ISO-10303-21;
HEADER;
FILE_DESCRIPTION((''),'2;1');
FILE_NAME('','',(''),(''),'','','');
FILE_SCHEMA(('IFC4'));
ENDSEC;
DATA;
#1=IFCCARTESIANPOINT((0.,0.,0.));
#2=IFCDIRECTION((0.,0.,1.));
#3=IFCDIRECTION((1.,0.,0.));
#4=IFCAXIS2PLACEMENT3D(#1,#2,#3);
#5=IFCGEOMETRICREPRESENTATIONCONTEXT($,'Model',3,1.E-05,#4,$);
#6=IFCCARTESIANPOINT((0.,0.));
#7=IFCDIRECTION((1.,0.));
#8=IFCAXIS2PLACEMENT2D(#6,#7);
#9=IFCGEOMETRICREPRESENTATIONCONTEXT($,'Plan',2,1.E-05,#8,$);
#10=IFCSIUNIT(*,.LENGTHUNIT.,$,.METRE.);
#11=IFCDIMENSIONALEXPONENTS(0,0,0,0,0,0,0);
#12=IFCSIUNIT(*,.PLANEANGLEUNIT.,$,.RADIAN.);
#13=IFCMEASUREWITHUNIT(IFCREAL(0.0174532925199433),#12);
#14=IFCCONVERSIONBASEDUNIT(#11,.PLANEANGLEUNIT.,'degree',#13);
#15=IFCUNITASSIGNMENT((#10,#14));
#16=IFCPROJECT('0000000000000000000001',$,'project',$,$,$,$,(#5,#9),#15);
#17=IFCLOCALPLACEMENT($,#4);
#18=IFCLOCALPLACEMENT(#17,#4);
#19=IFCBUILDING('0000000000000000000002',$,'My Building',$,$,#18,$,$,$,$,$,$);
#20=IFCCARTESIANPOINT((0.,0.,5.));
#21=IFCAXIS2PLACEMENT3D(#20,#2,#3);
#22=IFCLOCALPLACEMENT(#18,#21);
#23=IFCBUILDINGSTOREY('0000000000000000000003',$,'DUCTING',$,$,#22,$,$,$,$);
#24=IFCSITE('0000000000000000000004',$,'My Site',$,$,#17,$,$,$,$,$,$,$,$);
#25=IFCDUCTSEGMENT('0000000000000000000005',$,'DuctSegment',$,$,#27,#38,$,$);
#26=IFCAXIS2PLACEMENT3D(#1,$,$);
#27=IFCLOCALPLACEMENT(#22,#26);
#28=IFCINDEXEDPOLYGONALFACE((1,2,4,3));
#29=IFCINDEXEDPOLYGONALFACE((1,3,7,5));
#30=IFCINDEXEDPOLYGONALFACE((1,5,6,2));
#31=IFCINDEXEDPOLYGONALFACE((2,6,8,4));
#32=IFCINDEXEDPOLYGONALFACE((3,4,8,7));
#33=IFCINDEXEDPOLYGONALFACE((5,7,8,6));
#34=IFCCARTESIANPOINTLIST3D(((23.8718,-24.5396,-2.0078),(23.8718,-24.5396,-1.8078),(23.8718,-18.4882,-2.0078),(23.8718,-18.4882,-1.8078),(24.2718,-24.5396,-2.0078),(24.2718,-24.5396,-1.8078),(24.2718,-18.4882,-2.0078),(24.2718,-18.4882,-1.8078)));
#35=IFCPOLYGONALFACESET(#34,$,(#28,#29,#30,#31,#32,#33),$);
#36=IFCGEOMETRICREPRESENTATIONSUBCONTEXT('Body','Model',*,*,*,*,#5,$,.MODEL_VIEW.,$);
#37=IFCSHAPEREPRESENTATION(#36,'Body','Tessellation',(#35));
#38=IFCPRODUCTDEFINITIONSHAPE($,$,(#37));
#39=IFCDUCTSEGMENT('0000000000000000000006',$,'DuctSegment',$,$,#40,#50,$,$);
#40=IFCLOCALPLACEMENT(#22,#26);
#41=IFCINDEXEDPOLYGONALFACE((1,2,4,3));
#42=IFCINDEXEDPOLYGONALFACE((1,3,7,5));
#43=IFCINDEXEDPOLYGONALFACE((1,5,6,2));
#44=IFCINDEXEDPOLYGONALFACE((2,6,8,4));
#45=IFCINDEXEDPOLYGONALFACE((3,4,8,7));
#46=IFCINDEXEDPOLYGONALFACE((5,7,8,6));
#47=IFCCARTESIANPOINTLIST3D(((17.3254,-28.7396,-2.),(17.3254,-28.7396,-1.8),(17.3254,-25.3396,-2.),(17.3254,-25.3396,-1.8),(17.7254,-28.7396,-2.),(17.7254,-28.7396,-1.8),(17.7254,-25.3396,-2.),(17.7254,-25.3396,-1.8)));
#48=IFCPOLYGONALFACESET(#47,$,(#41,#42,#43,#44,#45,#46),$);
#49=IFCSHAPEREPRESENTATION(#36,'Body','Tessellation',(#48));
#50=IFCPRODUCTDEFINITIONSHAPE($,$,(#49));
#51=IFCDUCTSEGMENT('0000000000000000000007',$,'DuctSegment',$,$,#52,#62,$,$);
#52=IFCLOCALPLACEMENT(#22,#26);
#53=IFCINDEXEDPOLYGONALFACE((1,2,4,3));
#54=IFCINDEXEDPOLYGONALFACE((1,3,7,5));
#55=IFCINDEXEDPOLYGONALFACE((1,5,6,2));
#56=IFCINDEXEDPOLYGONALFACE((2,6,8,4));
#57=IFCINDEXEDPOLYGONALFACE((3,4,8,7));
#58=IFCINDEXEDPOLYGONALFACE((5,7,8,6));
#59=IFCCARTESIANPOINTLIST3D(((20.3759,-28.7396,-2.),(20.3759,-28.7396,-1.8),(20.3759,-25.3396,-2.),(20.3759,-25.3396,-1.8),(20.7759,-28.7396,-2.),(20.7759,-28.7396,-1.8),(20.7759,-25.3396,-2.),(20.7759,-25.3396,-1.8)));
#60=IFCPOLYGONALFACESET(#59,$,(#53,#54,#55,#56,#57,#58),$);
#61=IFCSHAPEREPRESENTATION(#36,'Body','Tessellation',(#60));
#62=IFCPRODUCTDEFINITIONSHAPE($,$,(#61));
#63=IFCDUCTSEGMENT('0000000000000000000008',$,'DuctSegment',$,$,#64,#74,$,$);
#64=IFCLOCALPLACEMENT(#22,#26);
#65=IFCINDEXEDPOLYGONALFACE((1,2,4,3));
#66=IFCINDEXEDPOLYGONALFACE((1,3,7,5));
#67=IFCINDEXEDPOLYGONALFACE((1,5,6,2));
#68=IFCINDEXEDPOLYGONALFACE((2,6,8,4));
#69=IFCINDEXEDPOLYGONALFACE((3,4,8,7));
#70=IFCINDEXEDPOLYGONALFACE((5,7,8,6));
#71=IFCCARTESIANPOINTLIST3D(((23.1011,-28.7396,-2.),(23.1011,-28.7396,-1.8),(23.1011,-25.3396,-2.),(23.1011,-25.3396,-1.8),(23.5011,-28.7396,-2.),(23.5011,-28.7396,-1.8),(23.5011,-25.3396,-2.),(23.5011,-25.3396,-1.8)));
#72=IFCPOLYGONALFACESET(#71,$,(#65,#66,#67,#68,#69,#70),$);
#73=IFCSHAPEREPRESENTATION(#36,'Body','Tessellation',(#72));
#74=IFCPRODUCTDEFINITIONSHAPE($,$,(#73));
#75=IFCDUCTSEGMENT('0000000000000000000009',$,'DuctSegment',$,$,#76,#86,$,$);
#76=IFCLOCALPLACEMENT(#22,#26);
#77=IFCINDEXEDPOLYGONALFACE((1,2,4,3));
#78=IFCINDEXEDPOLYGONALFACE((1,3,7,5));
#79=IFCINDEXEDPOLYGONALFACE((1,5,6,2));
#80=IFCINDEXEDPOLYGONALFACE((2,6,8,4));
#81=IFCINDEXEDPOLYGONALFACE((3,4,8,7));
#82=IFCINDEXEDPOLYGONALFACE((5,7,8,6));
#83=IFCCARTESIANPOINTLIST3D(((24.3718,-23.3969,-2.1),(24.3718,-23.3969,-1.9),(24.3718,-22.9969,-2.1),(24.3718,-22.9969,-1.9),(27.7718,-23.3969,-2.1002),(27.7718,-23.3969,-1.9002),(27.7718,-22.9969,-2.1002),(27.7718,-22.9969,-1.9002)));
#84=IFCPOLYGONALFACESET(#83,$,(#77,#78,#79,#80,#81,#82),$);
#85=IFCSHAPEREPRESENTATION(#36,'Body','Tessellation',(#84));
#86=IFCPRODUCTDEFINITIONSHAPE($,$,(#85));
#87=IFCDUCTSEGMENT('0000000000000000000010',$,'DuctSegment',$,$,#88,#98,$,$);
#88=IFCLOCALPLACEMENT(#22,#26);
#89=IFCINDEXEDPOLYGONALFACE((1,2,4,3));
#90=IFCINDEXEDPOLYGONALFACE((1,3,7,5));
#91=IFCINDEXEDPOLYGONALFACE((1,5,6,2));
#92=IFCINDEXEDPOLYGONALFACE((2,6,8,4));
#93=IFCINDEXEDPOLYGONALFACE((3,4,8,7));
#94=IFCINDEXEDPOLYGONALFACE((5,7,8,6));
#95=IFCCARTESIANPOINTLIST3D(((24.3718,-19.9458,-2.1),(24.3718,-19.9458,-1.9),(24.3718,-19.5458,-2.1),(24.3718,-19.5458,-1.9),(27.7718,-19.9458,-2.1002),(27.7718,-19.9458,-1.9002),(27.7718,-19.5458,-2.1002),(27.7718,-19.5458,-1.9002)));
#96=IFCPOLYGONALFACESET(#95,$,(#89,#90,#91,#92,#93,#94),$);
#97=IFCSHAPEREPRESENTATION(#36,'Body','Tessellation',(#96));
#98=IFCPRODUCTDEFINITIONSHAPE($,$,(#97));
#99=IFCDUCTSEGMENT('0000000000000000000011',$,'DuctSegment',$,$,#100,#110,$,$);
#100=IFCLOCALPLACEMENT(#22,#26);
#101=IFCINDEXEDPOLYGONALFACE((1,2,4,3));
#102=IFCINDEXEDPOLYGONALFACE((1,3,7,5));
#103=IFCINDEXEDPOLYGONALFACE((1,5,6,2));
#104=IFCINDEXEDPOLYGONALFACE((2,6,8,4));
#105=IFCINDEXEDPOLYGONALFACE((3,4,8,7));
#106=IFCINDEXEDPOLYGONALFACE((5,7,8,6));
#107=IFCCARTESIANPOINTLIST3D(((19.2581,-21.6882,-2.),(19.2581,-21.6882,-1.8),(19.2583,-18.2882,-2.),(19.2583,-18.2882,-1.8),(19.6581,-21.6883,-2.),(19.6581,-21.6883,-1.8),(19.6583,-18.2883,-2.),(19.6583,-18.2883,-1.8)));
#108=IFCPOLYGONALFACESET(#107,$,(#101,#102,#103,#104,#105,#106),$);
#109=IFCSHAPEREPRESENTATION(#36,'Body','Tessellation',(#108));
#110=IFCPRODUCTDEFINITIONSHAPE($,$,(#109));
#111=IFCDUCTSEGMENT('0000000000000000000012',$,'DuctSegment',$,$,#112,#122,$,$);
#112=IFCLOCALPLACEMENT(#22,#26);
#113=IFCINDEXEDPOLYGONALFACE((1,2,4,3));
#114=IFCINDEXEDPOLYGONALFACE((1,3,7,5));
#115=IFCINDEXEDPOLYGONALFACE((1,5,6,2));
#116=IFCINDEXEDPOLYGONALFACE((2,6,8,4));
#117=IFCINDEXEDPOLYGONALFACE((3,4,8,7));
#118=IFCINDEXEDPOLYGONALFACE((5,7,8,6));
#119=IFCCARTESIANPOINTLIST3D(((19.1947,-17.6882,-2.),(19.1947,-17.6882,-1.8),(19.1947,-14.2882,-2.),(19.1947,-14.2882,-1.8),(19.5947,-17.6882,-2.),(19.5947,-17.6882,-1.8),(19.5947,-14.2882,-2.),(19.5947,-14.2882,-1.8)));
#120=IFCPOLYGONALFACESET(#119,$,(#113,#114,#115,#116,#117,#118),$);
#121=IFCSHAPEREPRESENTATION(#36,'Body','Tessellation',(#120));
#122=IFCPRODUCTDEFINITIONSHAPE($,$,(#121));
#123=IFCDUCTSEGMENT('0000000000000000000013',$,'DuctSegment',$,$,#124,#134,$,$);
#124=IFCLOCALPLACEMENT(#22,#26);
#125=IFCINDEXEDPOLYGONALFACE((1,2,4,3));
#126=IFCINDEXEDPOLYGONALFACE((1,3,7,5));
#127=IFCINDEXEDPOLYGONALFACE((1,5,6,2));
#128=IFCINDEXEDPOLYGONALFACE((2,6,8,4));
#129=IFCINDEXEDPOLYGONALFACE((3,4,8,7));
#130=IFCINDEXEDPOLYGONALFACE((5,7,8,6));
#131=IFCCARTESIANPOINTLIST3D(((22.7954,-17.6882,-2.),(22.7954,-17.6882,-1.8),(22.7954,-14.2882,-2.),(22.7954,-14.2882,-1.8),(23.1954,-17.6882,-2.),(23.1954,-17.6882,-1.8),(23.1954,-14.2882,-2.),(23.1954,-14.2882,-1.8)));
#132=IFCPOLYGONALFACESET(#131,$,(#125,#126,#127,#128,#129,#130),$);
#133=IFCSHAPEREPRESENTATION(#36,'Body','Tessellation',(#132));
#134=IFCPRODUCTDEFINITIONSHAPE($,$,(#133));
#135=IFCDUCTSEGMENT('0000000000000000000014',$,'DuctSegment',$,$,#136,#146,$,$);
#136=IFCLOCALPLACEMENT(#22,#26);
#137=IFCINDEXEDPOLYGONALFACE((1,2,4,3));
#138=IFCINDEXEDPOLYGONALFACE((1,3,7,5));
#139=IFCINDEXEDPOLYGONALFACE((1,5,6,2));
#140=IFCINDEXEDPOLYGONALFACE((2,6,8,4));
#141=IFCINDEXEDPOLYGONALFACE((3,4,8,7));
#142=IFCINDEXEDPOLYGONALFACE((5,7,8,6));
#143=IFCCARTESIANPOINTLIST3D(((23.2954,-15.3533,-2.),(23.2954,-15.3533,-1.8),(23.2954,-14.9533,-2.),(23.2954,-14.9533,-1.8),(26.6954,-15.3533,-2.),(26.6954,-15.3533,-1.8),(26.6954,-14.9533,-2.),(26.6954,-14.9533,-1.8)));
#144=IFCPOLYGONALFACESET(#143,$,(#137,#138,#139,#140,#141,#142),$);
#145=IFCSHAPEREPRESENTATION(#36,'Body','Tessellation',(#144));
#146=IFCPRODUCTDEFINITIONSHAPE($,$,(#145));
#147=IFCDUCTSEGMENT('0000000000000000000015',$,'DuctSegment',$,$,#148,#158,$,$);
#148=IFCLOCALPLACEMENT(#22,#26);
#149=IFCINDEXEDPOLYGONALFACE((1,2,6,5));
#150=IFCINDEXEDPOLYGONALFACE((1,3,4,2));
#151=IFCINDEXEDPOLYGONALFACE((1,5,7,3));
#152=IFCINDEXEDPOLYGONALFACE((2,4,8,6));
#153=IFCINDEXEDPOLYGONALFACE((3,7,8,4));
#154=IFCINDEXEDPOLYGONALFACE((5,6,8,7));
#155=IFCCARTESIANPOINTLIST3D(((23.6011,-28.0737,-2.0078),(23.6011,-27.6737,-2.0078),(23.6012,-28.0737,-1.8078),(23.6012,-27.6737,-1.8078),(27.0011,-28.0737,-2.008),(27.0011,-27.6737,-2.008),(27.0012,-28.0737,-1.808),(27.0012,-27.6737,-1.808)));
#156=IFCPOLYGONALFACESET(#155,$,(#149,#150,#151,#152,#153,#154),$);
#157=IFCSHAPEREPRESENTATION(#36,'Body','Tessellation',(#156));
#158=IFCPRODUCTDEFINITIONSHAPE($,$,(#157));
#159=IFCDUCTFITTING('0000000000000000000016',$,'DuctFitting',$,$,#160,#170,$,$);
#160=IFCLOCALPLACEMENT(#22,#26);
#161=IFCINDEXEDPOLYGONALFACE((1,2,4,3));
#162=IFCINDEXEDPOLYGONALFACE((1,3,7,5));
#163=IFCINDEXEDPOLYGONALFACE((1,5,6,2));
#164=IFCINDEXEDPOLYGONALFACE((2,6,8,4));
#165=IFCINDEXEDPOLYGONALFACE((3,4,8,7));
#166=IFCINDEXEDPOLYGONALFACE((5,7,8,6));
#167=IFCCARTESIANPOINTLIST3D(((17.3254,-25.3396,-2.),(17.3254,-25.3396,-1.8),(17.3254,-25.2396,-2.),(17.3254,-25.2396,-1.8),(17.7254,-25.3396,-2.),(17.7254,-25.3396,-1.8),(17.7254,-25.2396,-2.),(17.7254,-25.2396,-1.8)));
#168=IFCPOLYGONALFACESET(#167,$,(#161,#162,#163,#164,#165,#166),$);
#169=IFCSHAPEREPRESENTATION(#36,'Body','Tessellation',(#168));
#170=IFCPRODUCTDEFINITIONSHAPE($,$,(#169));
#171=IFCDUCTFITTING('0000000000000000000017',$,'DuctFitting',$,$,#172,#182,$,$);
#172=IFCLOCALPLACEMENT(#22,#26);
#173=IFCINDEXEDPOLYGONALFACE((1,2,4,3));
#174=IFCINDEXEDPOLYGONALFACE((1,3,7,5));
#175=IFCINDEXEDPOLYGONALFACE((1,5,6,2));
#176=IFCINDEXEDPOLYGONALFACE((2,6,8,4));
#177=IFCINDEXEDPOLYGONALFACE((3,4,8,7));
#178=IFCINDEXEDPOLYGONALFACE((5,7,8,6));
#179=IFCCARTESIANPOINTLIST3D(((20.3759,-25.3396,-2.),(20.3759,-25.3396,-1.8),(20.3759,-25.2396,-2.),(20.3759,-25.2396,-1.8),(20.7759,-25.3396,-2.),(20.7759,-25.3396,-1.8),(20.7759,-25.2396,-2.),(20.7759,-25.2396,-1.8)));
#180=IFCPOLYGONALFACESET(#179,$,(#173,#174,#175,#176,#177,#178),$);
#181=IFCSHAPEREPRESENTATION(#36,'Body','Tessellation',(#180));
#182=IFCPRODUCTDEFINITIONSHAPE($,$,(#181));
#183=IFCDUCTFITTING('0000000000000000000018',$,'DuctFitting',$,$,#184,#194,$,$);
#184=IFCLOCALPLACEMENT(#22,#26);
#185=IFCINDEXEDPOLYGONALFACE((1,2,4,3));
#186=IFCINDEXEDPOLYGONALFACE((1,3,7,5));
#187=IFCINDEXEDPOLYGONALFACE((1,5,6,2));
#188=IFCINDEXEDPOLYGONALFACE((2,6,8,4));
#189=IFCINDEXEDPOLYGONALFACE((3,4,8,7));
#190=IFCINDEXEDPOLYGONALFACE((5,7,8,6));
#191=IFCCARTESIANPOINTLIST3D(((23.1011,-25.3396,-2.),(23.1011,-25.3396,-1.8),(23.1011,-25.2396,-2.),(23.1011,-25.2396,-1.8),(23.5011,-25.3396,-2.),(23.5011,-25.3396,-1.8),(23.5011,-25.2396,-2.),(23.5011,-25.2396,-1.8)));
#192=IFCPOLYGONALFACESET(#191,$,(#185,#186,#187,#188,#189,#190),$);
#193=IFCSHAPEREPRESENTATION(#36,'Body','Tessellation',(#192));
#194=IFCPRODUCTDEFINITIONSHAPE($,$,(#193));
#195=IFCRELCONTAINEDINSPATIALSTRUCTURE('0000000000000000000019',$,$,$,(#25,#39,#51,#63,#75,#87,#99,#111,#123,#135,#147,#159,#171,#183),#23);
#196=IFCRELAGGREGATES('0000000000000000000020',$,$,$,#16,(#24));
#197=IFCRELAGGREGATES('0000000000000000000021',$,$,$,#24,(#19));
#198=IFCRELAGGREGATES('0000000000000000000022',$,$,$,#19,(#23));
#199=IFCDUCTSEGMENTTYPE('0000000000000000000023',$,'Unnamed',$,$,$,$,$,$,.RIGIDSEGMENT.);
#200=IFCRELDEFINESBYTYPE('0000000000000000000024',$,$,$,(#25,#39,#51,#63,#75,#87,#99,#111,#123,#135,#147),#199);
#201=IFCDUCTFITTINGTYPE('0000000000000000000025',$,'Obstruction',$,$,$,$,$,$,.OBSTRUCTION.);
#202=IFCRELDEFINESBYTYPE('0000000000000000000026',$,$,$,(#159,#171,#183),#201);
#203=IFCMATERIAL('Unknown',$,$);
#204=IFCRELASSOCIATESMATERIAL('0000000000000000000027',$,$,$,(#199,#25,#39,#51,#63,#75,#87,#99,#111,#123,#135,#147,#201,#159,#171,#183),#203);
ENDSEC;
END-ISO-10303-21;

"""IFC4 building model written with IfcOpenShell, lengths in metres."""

from ifc_helpers import new_model, entity, si_unit, converted_unit, frame, origin_with_axes, origin_2d_with_axis, place, context, subcontext, project, spatial, rectangle, extrude, material, material_profile, profile_set, profile_usage, type_object, element, save


model = new_model("IFC4")

# Units and contexts
model_context = context("Model", 3, precision=1e-05, world=origin_with_axes())
plan_context = context("Plan", 2, precision=1e-05, world=origin_2d_with_axis())
body_context = subcontext(model_context, "Body", "Model", "MODEL_VIEW")
ifc_project = project(units=[si_unit("LENGTHUNIT", "METRE"), converted_unit("PLANEANGLEUNIT", "degree", entity("IfcReal", 0.0174532925199433), si_unit("PLANEANGLEUNIT", "RADIAN"), dimensions=[0, 0, 0, 0, 0, 0, 0])], contexts=[model_context, plan_context])

# Site, building, storey
site_placement = place(None, origin_with_axes())
site = spatial("IfcSite", under=ifc_project, at=site_placement, Name="My Site")
building_placement = place(site_placement, origin_with_axes())
building = spatial("IfcBuilding", under=site, at=building_placement, Name="My Building")
storey_placement = place(building_placement, frame((0.0, 0.0, 5.0), z_axis=(0.0, 0.0, 1.0), x_axis=(1.0, 0.0, 0.0)))
storey = spatial("IfcBuildingStorey", under=building, at=storey_placement, Name="DUCTING")

# Duct segments
ifc_material = material(Name="Unknown")
ifc_material_profile_1 = material_profile(ifc_material, rectangle(XDim=0.4, YDim=0.2))
ifc_profile_set_1 = profile_set([ifc_material_profile_1])
ifc_profile_usage_1 = profile_usage(ifc_profile_set_1, cardinal=5)
duct_segment_type = type_object("IfcDuctSegmentType", Name="Unnamed", PredefinedType="RIGIDSEGMENT", material=ifc_profile_set_1)
duct_segment_1_placement = place(storey_placement, frame((24.0718, -18.4882, -1.9078), z_axis=(0.0, -1.0, 0.0), x_axis=(1.0, 0.0, 0.0)))
element("IfcDuctSegment", 1, at=duct_segment_1_placement, inside=storey, type_object=duct_segment_type, material=ifc_profile_usage_1, Name="DuctSegment", context=body_context, shape_type="SweptSolid", body=[
    extrude(rectangle(XDim=0.4, YDim=0.2), origin_with_axes(), (0.0, 0.0, 1.0), 6.0513),
])
ifc_profile_usage_2 = profile_usage(ifc_profile_set_1, cardinal=5)
duct_segment_2_placement = place(storey_placement, frame((17.5254, -28.7396, -1.9), z_axis=(0.0, 1.0, 0.0), x_axis=(-1.0, 0.0, 0.0)))
element("IfcDuctSegment", 2, at=duct_segment_2_placement, inside=storey, type_object=duct_segment_type, material=ifc_profile_usage_2, Name="DuctSegment", context=body_context, shape_type="SweptSolid", body=[
    extrude(rectangle(XDim=0.4, YDim=0.2), origin_with_axes(), (0.0, 0.0, 1.0), 3.4),
])
ifc_profile_usage_3 = profile_usage(ifc_profile_set_1, cardinal=5)
duct_segment_3_placement = place(storey_placement, frame((20.5759, -28.7396, -1.9), z_axis=(0.0, 1.0, 0.0), x_axis=(-1.0, 0.0, 0.0)))
element("IfcDuctSegment", 3, at=duct_segment_3_placement, inside=storey, type_object=duct_segment_type, material=ifc_profile_usage_3, Name="DuctSegment", context=body_context, shape_type="SweptSolid", body=[
    extrude(rectangle(XDim=0.4, YDim=0.2), origin_with_axes(), (0.0, 0.0, 1.0), 3.4),
])
ifc_profile_usage_4 = profile_usage(ifc_profile_set_1, cardinal=5)
duct_segment_4_placement = place(storey_placement, frame((23.3011, -28.7396, -1.9), z_axis=(0.0, 1.0, 0.0), x_axis=(-1.0, 0.0, 0.0)))
element("IfcDuctSegment", 4, at=duct_segment_4_placement, inside=storey, type_object=duct_segment_type, material=ifc_profile_usage_4, Name="DuctSegment", context=body_context, shape_type="SweptSolid", body=[
    extrude(rectangle(XDim=0.4, YDim=0.2), origin_with_axes(), (0.0, 0.0, 1.0), 3.4),
])
ifc_profile_usage_5 = profile_usage(ifc_profile_set_1, cardinal=5)
duct_segment_5_placement = place(storey_placement, frame((24.3718, -23.1969, -2.0), z_axis=(1.0, 0.0, -0.000064), x_axis=(0.0, -1.0, 0.0)))
element("IfcDuctSegment", 5, at=duct_segment_5_placement, inside=storey, type_object=duct_segment_type, material=ifc_profile_usage_5, Name="DuctSegment", context=body_context, shape_type="SweptSolid", body=[
    extrude(rectangle(XDim=0.4, YDim=0.2), origin_with_axes(), (0.0, 0.0, 1.0), 3.4),
])
ifc_profile_usage_6 = profile_usage(ifc_profile_set_1, cardinal=5)
duct_segment_6_placement = place(storey_placement, frame((24.3718, -19.7458, -2.0), z_axis=(1.0, 0.0, -0.000064), x_axis=(0.0, -1.0, 0.0)))
element("IfcDuctSegment", 6, at=duct_segment_6_placement, inside=storey, type_object=duct_segment_type, material=ifc_profile_usage_6, Name="DuctSegment", context=body_context, shape_type="SweptSolid", body=[
    extrude(rectangle(XDim=0.4, YDim=0.2), origin_with_axes(), (0.0, 0.0, 1.0), 3.4),
])
ifc_profile_usage_7 = profile_usage(ifc_profile_set_1, cardinal=5)
duct_segment_7_placement = place(storey_placement, frame((19.4581, -21.6883, -1.9), z_axis=(0.000078, 1.0, 0.0), x_axis=(1.0, -0.000078, 0.0)))
element("IfcDuctSegment", 7, at=duct_segment_7_placement, inside=storey, type_object=duct_segment_type, material=ifc_profile_usage_7, Name="DuctSegment", context=body_context, shape_type="SweptSolid", body=[
    extrude(rectangle(XDim=0.4, YDim=0.2), origin_with_axes(), (0.0, 0.0, 1.0), 3.4),
])
ifc_profile_usage_8 = profile_usage(ifc_profile_set_1, cardinal=5)
duct_segment_8_placement = place(storey_placement, frame((19.3947, -17.6882, -1.9), z_axis=(0.0, 1.0, 0.0), x_axis=(-1.0, 0.0, 0.0)))
element("IfcDuctSegment", 8, at=duct_segment_8_placement, inside=storey, type_object=duct_segment_type, material=ifc_profile_usage_8, Name="DuctSegment", context=body_context, shape_type="SweptSolid", body=[
    extrude(rectangle(XDim=0.4, YDim=0.2), origin_with_axes(), (0.0, 0.0, 1.0), 3.4),
])
ifc_profile_usage_9 = profile_usage(ifc_profile_set_1, cardinal=5)
duct_segment_9_placement = place(storey_placement, frame((22.9954, -17.6882, -1.9), z_axis=(0.0, 1.0, 0.0), x_axis=(-1.0, 0.0, 0.0)))
element("IfcDuctSegment", 9, at=duct_segment_9_placement, inside=storey, type_object=duct_segment_type, material=ifc_profile_usage_9, Name="DuctSegment", context=body_context, shape_type="SweptSolid", body=[
    extrude(rectangle(XDim=0.4, YDim=0.2), origin_with_axes(), (0.0, 0.0, 1.0), 3.4),
])
ifc_profile_usage_10 = profile_usage(ifc_profile_set_1, cardinal=5)
duct_segment_10_placement = place(storey_placement, frame((23.2954, -15.1533, -1.9), z_axis=(1.0, 0.0, 0.0), x_axis=(0.0, -1.0, 0.0)))
element("IfcDuctSegment", 10, at=duct_segment_10_placement, inside=storey, type_object=duct_segment_type, material=ifc_profile_usage_10, Name="DuctSegment", context=body_context, shape_type="SweptSolid", body=[
    extrude(rectangle(XDim=0.4, YDim=0.2), origin_with_axes(), (0.0, 0.0, 1.0), 3.4),
])
ifc_profile_usage_11 = profile_usage(ifc_profile_set_1, cardinal=5)
duct_segment_11_placement = place(storey_placement, frame((23.6012, -27.8737, -1.9078), z_axis=(1.0, 0.0, -0.000064), x_axis=(0.0, -1.0, 0.0)))
element("IfcDuctSegment", 11, at=duct_segment_11_placement, inside=storey, type_object=duct_segment_type, material=ifc_profile_usage_11, Name="DuctSegment", context=body_context, shape_type="SweptSolid", body=[
    extrude(rectangle(XDim=0.4, YDim=0.2), origin_with_axes(), (0.0, 0.0, 1.0), 3.4),
])

# Duct fittings
ifc_material_profile_2 = material_profile(ifc_material, rectangle(XDim=0.4, YDim=0.2))
ifc_profile_set_2 = profile_set([ifc_material_profile_2])
ifc_profile_usage_12 = profile_usage(ifc_profile_set_2, cardinal=5)
duct_fitting_type = type_object("IfcDuctFittingType", Name="Obstruction", PredefinedType="OBSTRUCTION", material=ifc_profile_set_2)
duct_fitting_1_placement = place(storey_placement, frame((17.5254, -25.3396, -1.9), z_axis=(0.000001, 1.0, 0.000001), x_axis=(-1.0, 0.000001, 0.0)))
element("IfcDuctFitting", 12, at=duct_fitting_1_placement, inside=storey, type_object=duct_fitting_type, material=ifc_profile_usage_12, Name="DuctFitting", context=body_context, shape_type="SweptSolid", body=[
    extrude(rectangle(XDim=0.4, YDim=0.2), origin_with_axes(), (0.0, 0.0, 1.0), 0.1),
])
ifc_profile_usage_13 = profile_usage(ifc_profile_set_2, cardinal=5)
duct_fitting_2_placement = place(storey_placement, frame((20.5759, -25.3396, -1.9), z_axis=(0.000001, 1.0, 0.000001), x_axis=(-1.0, 0.000001, 0.0)))
element("IfcDuctFitting", 13, at=duct_fitting_2_placement, inside=storey, type_object=duct_fitting_type, material=ifc_profile_usage_13, Name="DuctFitting", context=body_context, shape_type="SweptSolid", body=[
    extrude(rectangle(XDim=0.4, YDim=0.2), origin_with_axes(), (0.0, 0.0, 1.0), 0.1),
])
ifc_profile_usage_14 = profile_usage(ifc_profile_set_2, cardinal=5)
duct_fitting_3_placement = place(storey_placement, frame((23.3011, -25.3396, -1.9), z_axis=(0.000001, 1.0, 0.000001), x_axis=(-1.0, 0.000001, 0.0)))
element("IfcDuctFitting", 14, at=duct_fitting_3_placement, inside=storey, type_object=duct_fitting_type, material=ifc_profile_usage_14, Name="DuctFitting", context=body_context, shape_type="SweptSolid", body=[
    extrude(rectangle(XDim=0.4, YDim=0.2), origin_with_axes(), (0.0, 0.0, 1.0), 0.1),
])

save(model, "model.ifc")
